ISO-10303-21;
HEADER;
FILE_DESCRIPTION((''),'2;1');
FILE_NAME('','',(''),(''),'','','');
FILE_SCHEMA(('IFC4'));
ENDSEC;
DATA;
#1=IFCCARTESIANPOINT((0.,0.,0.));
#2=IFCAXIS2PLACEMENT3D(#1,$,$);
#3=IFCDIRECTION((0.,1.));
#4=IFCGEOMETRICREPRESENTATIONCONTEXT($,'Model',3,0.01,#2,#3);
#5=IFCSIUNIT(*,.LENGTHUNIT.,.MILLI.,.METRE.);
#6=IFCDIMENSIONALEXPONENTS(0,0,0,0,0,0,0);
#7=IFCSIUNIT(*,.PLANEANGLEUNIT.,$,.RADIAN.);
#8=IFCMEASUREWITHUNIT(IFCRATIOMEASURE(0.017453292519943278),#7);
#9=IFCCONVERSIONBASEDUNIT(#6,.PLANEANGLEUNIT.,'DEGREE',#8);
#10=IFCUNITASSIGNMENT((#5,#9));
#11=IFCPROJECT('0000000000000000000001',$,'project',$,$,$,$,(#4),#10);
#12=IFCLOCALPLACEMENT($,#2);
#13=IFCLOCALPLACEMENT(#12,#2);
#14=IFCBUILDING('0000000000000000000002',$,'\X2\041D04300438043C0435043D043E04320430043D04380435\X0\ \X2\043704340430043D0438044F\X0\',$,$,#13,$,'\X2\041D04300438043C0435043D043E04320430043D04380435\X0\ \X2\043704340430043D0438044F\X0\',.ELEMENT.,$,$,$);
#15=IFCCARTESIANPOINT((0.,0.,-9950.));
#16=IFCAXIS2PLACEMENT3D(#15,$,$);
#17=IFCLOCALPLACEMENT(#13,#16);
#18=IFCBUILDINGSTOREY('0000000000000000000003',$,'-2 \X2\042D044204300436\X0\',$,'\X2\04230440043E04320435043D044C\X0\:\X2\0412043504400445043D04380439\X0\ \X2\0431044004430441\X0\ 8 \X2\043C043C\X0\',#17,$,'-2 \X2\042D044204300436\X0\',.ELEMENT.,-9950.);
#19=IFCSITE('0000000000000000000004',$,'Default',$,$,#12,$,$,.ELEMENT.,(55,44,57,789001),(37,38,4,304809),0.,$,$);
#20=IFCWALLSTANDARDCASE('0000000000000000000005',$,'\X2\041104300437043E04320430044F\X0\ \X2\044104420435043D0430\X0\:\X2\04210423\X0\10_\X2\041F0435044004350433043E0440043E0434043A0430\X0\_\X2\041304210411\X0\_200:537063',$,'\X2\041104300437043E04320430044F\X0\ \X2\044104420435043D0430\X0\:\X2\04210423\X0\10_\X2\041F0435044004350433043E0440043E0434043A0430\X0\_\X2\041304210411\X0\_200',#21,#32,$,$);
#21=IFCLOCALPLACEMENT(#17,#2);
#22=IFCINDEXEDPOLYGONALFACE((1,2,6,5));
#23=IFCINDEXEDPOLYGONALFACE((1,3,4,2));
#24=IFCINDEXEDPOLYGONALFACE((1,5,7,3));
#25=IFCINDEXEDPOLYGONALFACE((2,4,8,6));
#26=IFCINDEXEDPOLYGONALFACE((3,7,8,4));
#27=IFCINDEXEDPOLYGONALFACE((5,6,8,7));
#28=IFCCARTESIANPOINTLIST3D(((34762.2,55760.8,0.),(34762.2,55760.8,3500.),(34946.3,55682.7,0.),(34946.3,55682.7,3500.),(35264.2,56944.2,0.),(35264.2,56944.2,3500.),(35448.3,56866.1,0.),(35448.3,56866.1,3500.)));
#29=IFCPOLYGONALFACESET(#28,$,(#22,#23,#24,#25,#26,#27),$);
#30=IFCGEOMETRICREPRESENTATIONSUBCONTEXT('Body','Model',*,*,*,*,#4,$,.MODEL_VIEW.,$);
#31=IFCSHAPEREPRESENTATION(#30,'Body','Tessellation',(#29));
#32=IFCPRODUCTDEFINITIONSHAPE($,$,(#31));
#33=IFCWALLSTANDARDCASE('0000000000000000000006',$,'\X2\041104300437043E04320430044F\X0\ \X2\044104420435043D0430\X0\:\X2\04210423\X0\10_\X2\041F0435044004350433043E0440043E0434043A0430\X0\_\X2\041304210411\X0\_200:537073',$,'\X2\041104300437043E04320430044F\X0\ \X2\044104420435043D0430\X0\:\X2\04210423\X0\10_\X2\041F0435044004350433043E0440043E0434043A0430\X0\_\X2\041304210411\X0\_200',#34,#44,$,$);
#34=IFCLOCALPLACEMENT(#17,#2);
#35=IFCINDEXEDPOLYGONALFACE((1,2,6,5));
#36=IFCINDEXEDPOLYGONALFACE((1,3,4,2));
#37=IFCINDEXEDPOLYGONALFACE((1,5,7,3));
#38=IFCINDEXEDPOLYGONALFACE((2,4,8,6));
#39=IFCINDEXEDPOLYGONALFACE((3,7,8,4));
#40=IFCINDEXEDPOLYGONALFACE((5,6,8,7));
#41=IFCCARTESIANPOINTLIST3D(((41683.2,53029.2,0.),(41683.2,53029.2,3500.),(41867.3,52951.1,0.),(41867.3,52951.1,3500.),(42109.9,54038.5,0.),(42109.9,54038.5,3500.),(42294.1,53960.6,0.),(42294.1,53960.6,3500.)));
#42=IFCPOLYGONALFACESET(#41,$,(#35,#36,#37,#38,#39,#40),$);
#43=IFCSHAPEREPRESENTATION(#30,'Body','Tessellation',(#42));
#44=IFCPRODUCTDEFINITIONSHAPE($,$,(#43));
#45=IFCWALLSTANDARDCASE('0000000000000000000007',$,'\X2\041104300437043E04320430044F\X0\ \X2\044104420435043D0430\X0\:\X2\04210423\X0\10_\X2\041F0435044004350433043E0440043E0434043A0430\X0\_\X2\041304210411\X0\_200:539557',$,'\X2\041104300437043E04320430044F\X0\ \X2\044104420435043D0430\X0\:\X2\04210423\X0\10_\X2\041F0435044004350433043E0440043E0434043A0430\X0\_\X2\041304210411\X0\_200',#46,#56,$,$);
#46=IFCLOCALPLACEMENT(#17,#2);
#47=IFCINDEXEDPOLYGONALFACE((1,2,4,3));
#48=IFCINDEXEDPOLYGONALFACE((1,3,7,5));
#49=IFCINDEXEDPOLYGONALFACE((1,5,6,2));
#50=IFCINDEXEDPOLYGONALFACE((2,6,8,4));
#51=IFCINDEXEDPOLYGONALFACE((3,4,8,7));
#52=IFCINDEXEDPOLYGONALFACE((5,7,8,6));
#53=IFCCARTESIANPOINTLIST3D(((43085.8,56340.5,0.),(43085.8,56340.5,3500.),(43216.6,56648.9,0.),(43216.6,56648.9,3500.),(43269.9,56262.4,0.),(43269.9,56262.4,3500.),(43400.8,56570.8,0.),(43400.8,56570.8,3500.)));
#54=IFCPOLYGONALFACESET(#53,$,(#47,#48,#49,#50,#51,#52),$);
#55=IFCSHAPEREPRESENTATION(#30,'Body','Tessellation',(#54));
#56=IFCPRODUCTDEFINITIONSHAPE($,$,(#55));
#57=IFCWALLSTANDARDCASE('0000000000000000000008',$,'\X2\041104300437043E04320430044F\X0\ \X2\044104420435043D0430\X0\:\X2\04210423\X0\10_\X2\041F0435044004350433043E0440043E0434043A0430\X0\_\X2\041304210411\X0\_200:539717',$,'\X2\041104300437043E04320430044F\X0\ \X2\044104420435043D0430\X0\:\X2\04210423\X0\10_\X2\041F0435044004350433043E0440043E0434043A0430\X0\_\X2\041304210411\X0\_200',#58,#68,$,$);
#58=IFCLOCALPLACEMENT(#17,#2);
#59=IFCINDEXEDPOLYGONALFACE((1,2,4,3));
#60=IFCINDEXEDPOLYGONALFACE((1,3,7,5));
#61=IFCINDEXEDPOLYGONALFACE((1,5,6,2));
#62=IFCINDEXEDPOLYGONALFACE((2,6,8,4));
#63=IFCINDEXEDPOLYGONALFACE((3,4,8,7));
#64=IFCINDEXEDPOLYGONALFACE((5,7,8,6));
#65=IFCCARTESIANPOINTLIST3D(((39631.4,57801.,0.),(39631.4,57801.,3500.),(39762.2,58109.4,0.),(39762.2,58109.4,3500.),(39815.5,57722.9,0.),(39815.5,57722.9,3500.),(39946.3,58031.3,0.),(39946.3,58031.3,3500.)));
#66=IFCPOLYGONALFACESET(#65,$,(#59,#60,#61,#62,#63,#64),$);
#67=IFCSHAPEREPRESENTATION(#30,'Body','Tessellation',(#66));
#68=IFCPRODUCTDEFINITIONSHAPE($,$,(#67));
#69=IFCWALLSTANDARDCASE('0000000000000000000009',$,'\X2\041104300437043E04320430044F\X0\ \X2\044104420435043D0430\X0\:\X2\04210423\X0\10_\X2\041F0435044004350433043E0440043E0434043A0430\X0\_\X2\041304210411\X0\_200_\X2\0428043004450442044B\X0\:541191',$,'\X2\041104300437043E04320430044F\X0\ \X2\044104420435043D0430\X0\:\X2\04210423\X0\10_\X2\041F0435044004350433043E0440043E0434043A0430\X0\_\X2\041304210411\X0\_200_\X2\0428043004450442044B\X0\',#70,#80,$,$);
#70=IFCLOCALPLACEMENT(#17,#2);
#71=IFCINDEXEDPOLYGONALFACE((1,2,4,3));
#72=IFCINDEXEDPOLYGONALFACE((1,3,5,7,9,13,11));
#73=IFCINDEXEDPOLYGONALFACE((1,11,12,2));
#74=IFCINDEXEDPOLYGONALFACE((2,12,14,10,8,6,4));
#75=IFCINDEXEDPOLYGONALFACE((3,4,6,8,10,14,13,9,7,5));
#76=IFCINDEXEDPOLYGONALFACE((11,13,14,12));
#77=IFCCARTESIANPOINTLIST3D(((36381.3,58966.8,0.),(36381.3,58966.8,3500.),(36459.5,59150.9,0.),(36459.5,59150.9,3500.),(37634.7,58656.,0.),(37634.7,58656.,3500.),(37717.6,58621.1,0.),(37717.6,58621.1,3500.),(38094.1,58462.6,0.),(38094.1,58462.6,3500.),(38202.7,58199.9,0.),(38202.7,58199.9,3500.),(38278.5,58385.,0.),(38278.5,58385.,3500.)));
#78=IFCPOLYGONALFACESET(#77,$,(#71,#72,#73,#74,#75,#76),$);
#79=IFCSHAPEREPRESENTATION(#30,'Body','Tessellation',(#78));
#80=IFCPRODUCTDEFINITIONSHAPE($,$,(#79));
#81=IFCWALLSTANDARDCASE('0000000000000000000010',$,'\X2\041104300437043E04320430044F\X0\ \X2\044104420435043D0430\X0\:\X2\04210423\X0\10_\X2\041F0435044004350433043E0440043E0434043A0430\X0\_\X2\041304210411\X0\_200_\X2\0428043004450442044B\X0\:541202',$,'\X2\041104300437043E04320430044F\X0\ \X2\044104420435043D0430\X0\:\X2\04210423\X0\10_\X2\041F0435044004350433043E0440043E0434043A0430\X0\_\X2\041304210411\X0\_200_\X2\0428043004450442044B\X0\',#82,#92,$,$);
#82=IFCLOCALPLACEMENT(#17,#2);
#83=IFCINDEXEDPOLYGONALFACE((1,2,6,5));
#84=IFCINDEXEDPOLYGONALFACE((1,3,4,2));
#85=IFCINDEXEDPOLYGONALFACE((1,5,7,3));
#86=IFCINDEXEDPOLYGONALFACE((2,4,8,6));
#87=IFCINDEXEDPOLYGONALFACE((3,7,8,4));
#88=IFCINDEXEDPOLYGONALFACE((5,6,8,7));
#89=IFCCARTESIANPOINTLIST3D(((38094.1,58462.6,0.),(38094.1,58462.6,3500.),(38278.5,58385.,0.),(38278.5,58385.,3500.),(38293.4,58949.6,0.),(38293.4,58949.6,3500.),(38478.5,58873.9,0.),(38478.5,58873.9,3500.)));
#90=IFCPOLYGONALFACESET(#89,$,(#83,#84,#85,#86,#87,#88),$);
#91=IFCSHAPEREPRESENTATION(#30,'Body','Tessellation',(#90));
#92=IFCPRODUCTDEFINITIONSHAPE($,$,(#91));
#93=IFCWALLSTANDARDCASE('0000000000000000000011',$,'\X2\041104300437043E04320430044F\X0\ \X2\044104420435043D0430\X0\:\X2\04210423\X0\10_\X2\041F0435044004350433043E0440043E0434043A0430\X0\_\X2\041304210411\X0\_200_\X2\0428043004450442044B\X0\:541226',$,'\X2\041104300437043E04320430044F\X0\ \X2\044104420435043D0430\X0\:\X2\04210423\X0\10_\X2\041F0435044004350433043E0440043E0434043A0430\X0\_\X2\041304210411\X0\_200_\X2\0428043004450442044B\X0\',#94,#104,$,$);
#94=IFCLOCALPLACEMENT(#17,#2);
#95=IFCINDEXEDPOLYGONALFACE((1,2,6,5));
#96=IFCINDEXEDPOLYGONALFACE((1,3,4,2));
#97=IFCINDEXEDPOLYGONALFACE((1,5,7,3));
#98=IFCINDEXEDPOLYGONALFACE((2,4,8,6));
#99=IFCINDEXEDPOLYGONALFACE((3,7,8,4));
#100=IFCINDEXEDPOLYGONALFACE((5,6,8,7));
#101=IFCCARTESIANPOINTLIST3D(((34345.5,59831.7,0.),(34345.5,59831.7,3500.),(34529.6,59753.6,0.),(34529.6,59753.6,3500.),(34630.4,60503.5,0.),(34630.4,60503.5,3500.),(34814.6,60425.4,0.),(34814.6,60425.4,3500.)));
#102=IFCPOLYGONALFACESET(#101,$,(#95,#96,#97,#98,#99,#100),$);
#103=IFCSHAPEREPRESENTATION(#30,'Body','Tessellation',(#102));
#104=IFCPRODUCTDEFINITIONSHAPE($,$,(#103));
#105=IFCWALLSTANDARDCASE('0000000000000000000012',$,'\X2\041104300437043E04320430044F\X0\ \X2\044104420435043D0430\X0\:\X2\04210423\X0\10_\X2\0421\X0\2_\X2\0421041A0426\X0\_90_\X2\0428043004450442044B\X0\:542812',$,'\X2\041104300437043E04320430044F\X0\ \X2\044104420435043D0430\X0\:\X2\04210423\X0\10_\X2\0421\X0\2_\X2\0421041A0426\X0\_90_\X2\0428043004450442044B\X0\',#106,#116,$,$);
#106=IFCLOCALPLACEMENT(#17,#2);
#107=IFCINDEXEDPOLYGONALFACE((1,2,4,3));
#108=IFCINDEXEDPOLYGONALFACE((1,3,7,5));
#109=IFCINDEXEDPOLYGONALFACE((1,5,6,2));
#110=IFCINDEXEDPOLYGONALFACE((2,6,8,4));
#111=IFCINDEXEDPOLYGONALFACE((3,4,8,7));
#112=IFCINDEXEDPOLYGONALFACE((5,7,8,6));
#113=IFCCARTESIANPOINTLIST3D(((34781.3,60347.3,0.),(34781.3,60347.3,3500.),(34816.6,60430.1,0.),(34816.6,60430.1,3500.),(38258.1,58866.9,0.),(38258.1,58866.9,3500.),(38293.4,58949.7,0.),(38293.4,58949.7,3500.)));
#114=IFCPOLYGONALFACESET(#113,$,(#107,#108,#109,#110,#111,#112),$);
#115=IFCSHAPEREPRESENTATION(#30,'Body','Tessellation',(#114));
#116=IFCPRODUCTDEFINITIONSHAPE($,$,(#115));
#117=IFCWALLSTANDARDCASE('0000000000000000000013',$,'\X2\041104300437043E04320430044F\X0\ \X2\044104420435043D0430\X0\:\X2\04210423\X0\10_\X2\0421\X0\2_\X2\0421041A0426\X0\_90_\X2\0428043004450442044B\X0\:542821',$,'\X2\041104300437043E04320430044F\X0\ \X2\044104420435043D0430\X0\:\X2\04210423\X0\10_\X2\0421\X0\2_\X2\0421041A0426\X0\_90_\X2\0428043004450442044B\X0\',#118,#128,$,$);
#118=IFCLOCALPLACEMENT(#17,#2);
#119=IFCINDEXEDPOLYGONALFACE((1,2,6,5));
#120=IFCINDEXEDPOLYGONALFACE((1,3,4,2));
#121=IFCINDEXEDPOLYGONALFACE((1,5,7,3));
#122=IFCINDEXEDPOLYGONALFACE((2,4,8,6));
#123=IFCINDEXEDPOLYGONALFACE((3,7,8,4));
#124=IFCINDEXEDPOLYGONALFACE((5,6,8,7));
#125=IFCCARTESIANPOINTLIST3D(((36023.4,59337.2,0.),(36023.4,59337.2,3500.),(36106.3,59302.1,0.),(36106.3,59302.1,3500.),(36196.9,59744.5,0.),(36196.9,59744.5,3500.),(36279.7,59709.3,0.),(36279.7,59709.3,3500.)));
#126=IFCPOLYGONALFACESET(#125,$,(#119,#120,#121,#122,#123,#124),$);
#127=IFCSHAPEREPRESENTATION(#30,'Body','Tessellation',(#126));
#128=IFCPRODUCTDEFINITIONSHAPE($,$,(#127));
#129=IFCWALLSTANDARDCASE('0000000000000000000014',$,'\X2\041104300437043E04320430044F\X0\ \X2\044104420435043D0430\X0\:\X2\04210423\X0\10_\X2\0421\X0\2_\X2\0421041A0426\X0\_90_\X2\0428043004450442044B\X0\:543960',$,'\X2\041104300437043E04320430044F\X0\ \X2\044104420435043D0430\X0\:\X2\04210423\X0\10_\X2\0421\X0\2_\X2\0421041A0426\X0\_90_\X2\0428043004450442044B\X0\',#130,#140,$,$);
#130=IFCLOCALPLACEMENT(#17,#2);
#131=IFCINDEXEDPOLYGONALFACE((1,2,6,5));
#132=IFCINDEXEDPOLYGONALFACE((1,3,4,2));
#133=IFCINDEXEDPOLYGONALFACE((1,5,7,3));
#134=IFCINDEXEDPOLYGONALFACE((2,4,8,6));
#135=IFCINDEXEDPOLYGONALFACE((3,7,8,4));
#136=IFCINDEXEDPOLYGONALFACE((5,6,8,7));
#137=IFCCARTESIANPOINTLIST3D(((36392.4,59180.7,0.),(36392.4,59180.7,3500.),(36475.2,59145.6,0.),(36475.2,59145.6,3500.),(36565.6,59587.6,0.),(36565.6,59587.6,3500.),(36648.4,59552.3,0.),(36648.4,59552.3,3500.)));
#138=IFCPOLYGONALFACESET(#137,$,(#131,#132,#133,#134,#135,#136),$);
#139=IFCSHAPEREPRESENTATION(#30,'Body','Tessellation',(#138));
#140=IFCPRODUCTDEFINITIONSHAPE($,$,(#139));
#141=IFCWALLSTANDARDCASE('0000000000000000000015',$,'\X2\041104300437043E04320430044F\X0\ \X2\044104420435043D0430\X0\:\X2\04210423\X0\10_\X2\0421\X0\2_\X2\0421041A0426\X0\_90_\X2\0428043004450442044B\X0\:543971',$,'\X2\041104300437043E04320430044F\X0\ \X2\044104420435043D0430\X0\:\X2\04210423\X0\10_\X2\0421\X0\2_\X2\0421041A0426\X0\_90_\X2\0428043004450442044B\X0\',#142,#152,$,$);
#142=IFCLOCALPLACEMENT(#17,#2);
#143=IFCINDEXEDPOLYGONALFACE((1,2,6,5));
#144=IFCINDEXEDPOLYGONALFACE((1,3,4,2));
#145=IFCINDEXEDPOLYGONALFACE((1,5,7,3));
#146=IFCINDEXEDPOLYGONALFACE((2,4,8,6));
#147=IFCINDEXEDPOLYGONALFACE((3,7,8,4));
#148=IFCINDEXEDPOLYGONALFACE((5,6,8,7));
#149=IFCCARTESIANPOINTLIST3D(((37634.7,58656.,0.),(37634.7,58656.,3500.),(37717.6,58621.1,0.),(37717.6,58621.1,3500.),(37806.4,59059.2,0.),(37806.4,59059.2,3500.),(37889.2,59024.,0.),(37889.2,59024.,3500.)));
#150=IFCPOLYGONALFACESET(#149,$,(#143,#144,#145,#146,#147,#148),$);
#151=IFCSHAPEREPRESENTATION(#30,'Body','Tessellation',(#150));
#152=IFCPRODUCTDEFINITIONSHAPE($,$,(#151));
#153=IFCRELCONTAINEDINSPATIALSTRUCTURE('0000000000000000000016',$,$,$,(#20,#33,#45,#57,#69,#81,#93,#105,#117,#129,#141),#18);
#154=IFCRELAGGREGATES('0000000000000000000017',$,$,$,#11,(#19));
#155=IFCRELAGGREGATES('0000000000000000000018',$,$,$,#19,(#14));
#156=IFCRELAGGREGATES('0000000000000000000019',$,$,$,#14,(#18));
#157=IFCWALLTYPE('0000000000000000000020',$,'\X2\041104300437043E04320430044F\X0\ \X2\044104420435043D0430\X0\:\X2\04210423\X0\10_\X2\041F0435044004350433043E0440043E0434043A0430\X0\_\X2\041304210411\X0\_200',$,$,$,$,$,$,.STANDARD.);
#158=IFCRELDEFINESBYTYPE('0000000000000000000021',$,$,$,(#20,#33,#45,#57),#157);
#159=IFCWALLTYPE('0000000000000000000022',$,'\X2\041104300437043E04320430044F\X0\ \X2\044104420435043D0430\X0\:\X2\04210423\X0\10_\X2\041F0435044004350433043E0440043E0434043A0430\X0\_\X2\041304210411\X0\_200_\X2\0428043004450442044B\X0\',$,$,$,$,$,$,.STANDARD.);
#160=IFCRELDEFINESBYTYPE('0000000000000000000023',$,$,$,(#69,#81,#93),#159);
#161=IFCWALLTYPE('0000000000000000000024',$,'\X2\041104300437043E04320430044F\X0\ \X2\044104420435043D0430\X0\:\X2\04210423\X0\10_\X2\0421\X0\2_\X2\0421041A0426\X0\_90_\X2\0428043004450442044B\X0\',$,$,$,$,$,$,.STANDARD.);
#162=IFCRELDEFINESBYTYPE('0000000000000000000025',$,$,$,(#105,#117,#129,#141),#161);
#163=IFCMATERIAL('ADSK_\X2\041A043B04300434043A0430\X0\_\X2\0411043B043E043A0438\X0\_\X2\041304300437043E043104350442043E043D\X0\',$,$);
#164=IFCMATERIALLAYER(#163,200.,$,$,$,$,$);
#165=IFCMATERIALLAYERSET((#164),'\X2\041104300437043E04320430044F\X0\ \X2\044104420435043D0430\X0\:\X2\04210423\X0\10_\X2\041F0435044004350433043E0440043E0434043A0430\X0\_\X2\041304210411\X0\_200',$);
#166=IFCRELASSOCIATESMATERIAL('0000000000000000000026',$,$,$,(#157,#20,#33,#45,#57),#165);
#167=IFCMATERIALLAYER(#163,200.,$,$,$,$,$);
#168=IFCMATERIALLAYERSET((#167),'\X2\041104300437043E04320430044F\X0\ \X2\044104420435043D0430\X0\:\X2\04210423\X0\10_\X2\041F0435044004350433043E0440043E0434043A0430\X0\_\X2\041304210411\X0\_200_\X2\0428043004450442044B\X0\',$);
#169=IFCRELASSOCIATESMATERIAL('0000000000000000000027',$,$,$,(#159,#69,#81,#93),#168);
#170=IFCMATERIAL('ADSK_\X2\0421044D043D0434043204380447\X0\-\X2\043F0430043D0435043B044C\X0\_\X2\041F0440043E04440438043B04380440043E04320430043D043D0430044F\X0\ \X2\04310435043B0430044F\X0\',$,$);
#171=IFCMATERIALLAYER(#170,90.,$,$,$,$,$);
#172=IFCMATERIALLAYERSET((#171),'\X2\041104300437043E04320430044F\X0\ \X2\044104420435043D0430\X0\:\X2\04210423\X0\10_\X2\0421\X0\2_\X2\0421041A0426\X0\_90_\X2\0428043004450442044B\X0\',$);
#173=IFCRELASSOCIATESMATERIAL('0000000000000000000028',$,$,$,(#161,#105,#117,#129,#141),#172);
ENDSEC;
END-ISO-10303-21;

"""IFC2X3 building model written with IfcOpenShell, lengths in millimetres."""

from ifc_helpers import new_model, entity, si_unit, converted_unit, direction, frame, frame_2d, origin, place, context, subcontext, project, spatial, polyline, rectangle, outline, extrude, material, layer, layer_set, layer_usage, type_object, element, save


model = new_model("IFC2X3")

# Units and contexts
model_context = context("Model", 3, precision=0.01, world=origin(), true_north=direction((0.0, 1.0)))
body_context = subcontext(model_context, "Body", "Model", "MODEL_VIEW")
ifc_project = project(units=[si_unit("LENGTHUNIT", "METRE", prefix="MILLI"), converted_unit("PLANEANGLEUNIT", "DEGREE", entity("IfcRatioMeasure", 0.017453292519943278), si_unit("PLANEANGLEUNIT", "RADIAN"), dimensions=[0, 0, 0, 0, 0, 0, 0])], contexts=[model_context])

# Site, building, storey
site_placement = place(None, origin())
site = spatial("IfcSite", under=ifc_project, at=site_placement, Name="Default", CompositionType="ELEMENT", RefLatitude=(55, 44, 57, 789001), RefLongitude=(37, 38, 4, 304809), RefElevation=0.0)
building_placement = place(site_placement, origin())
building = spatial("IfcBuilding", under=site, at=building_placement, Name="Наименование здания", LongName="Наименование здания", CompositionType="ELEMENT")
storey_placement = place(building_placement, frame((0.0, 0.0, -9950.0)))
storey = spatial("IfcBuildingStorey", under=building, at=storey_placement, Name="-2 Этаж", ObjectType="Уровень:Верхний брус 8 мм", LongName="-2 Этаж", CompositionType="ELEMENT", Elevation=-9950.0)

# Shared definitions
ifc_material_1 = material(Name="ADSK_Сэндвич-панель_Профилированная белая")

# Shared definitions
ifc_material_2 = material(Name="ADSK_Кладка_Блоки_Газобетон")
ifc_layer_1 = layer(ifc_material_2, 200.0)
ifc_layer_set_1 = layer_set([ifc_layer_1], Name="Базовая стена:СУ10_Перегородка_ГСБ_200")
ifc_layer_usage_1 = layer_usage(ifc_layer_set_1, "AXIS2", "NEGATIVE", 100.0)
wall_type_1 = type_object("IfcWallType", Name="Базовая стена:СУ10_Перегородка_ГСБ_200", PredefinedType="STANDARD", material=ifc_layer_set_1)

# Walls
wall_1_placement = place(storey_placement, frame((34854.2, 55721.8, 0.0), z_axis=(0.0, 0.0, 1.0), x_axis=(0.390507, 0.9206, 0.0)))
element("IfcWallStandardCase", 1, at=wall_1_placement, inside=storey, type_object=wall_type_1, material=ifc_layer_usage_1, Name="Базовая стена:СУ10_Перегородка_ГСБ_200:537063", ObjectType="Базовая стена:СУ10_Перегородка_ГСБ_200", context=body_context, shape_type="SweptSolid", body=[
    extrude(rectangle(XDim=1285.5, YDim=200.0, at=frame_2d((642.7, 0.0), x_axis=(-1.0, 0.0))), origin(), (0.0, 0.0, 1.0), 3500.0),
])
wall_2_placement = place(storey_placement, frame((41775.2, 52990.1, 0.0), z_axis=(0.0, 0.0, 1.0), x_axis=(0.389417, 0.921062, 0.0)))
element("IfcWallStandardCase", 2, at=wall_2_placement, inside=storey, type_object=wall_type_1, material=ifc_layer_usage_1, Name="Базовая стена:СУ10_Перегородка_ГСБ_200:537073", ObjectType="Базовая стена:СУ10_Перегородка_ГСБ_200", context=body_context, shape_type="SweptSolid", body=[
    extrude(outline(polyline([(1096.0, -100.0), (1096.0, 100.0), (0.2, 100.0), (0.0, -100.0), (1096.0, -100.0)])), origin(), (0.0, 0.0, 1.0), 3500.0),
])
wall_3_placement = place(storey_placement, frame((43177.9, 56301.4, 0.0), z_axis=(0.0, 0.0, 1.0), x_axis=(0.39055, 0.920582, 0.0)))
element("IfcWallStandardCase", 3, at=wall_3_placement, inside=storey, type_object=wall_type_1, material=ifc_layer_usage_1, Name="Базовая стена:СУ10_Перегородка_ГСБ_200:539557", ObjectType="Базовая стена:СУ10_Перегородка_ГСБ_200", context=body_context, shape_type="SweptSolid", body=[
    extrude(rectangle(XDim=335.0, YDim=200.0, at=frame_2d((167.5, 0.0), x_axis=(-1.0, 0.0))), origin(), (0.0, 0.0, 1.0), 3500.0),
])
wall_4_placement = place(storey_placement, frame((39723.4, 57762.0, 0.0), z_axis=(0.0, 0.0, 1.0), x_axis=(0.39055, 0.920582, 0.0)))
element("IfcWallStandardCase", 4, at=wall_4_placement, inside=storey, type_object=wall_type_1, material=ifc_layer_usage_1, Name="Базовая стена:СУ10_Перегородка_ГСБ_200:539717", ObjectType="Базовая стена:СУ10_Перегородка_ГСБ_200", context=body_context, shape_type="SweptSolid", body=[
    extrude(rectangle(XDim=335.0, YDim=200.0, at=frame_2d((167.5, 0.0), x_axis=(-1.0, 0.0))), origin(), (0.0, 0.0, 1.0), 3500.0),
])
ifc_layer_2 = layer(ifc_material_2, 200.0)
ifc_layer_set_2 = layer_set([ifc_layer_2], Name="Базовая стена:СУ10_Перегородка_ГСБ_200_Шахты")
ifc_layer_usage_2 = layer_usage(ifc_layer_set_2, "AXIS2", "NEGATIVE", 100.0)
wall_type_2 = type_object("IfcWallType", Name="Базовая стена:СУ10_Перегородка_ГСБ_200_Шахты", PredefinedType="STANDARD", material=ifc_layer_set_2)
wall_5_placement = place(storey_placement, frame((36420.2, 59058.9, 0.0), z_axis=(0.0, 0.0, 1.0), x_axis=(0.921635, -0.388057, 0.0)))
element("IfcWallStandardCase", 5, at=wall_5_placement, inside=storey, type_object=wall_type_2, material=ifc_layer_usage_2, Name="Базовая стена:СУ10_Перегородка_ГСБ_200_Шахты:541191", ObjectType="Базовая стена:СУ10_Перегородка_ГСБ_200_Шахты", context=body_context, shape_type="SweptSolid", body=[
    extrude(outline(polyline([(1976.3, -100.0), (1974.2, 100.0), (1774.2, 100.0), (1365.7, 100.0), (1275.7, 100.0), (0.5, 100.0), (0.0, -100.0), (1976.3, -100.0)])), origin(), (0.0, 0.0, 1.0), 3500.0),
])
wall_6_placement = place(storey_placement, frame((38185.9, 58422.8, 0.0), z_axis=(0.0, 0.0, 1.0), x_axis=(0.378633, 0.925547, 0.0)))
element("IfcWallStandardCase", 6, at=wall_6_placement, inside=storey, type_object=wall_type_2, material=ifc_layer_usage_2, Name="Базовая стена:СУ10_Перегородка_ГСБ_200_Шахты:541202", ObjectType="Базовая стена:СУ10_Перегородка_ГСБ_200_Шахты", context=body_context, shape_type="SweptSolid", body=[
    extrude(outline(polyline([(528.2, -100.0), (528.2, 100.0), (2.0, 100.0), (0.0, -100.0), (528.2, -100.0)])), origin(), (0.0, 0.0, 1.0), 3500.0),
])
wall_7_placement = place(storey_placement, frame((34437.5, 59792.7, 0.0), z_axis=(0.0, 0.0, 1.0), x_axis=(0.390507, 0.9206, 0.0)))
element("IfcWallStandardCase", 7, at=wall_7_placement, inside=storey, type_object=wall_type_2, material=ifc_layer_usage_2, Name="Базовая стена:СУ10_Перегородка_ГСБ_200_Шахты:541226", ObjectType="Базовая стена:СУ10_Перегородка_ГСБ_200_Шахты", context=body_context, shape_type="SweptSolid", body=[
    extrude(rectangle(XDim=729.7, YDim=200.0, at=frame_2d((364.9, 0.0), x_axis=(-1.0, 0.0))), origin(), (0.0, 0.0, 1.0), 3500.0),
])
ifc_layer_3 = layer(ifc_material_1, 90.0)
ifc_layer_set_3 = layer_set([ifc_layer_3], Name="Базовая стена:СУ10_С2_СКЦ_90_Шахты")
ifc_layer_usage_3 = layer_usage(ifc_layer_set_3, "AXIS2", "NEGATIVE", 45.0)
wall_type_3 = type_object("IfcWallType", Name="Базовая стена:СУ10_С2_СКЦ_90_Шахты", PredefinedType="STANDARD", material=ifc_layer_set_3)
wall_8_placement = place(storey_placement, frame((38275.8, 58908.3, 0.0), z_axis=(0.0, 0.0, 1.0), x_axis=(-0.920069, 0.391757, 0.0)))
element("IfcWallStandardCase", 8, at=wall_8_placement, inside=storey, type_object=wall_type_3, material=ifc_layer_usage_3, Name="Базовая стена:СУ10_С2_СКЦ_90_Шахты:542812", ObjectType="Базовая стена:СУ10_С2_СКЦ_90_Шахты", context=body_context, shape_type="SweptSolid", body=[
    extrude(rectangle(XDim=3778.9, YDim=90.0, at=frame_2d((1889.4, 0.0), x_axis=(-1.0, 0.0))), origin(), (0.0, 0.0, 1.0), 3500.0),
])
wall_9_placement = place(storey_placement, frame((36238.3, 59726.9, 0.0), z_axis=(0.0, 0.0, 1.0), x_axis=(-0.391757, -0.920069, 0.0)))
element("IfcWallStandardCase", 9, at=wall_9_placement, inside=storey, type_object=wall_type_3, material=ifc_layer_usage_3, Name="Базовая стена:СУ10_С2_СКЦ_90_Шахты:542821", ObjectType="Базовая стена:СУ10_С2_СКЦ_90_Шахты", context=body_context, shape_type="SweptSolid", body=[
    extrude(outline(polyline([(442.7, -45.0), (442.6, 45.0), (0.0, 45.0), (0.0, -45.0), (442.7, -45.0)])), origin(), (0.0, 0.0, 1.0), 3500.0),
])
wall_10_placement = place(storey_placement, frame((36607.0, 59569.9, 0.0), z_axis=(0.0, 0.0, 1.0), x_axis=(-0.391757, -0.920069, 0.0)))
element("IfcWallStandardCase", 10, at=wall_10_placement, inside=storey, type_object=wall_type_3, material=ifc_layer_usage_3, Name="Базовая стена:СУ10_С2_СКЦ_90_Шахты:543960", ObjectType="Базовая стена:СУ10_С2_СКЦ_90_Шахты", context=body_context, shape_type="SweptSolid", body=[
    extrude(outline(polyline([(442.2, -45.0), (442.0, 45.0), (0.0, 45.0), (0.0, -45.0), (442.2, -45.0)])), origin(), (0.0, 0.0, 1.0), 3500.0),
])
wall_11_placement = place(storey_placement, frame((37847.8, 59041.6, 0.0), z_axis=(0.0, 0.0, 1.0), x_axis=(-0.391757, -0.920069, 0.0)))
element("IfcWallStandardCase", 11, at=wall_11_placement, inside=storey, type_object=wall_type_3, material=ifc_layer_usage_3, Name="Базовая стена:СУ10_С2_СКЦ_90_Шахты:543971", ObjectType="Базовая стена:СУ10_С2_СКЦ_90_Шахты", context=body_context, shape_type="SweptSolid", body=[
    extrude(outline(polyline([(438.2, -45.0), (437.9, 45.0), (0.0, 45.0), (0.0, -45.0), (438.2, -45.0)])), origin(), (0.0, 0.0, 1.0), 3500.0),
])

save(model, "model.ifc")
